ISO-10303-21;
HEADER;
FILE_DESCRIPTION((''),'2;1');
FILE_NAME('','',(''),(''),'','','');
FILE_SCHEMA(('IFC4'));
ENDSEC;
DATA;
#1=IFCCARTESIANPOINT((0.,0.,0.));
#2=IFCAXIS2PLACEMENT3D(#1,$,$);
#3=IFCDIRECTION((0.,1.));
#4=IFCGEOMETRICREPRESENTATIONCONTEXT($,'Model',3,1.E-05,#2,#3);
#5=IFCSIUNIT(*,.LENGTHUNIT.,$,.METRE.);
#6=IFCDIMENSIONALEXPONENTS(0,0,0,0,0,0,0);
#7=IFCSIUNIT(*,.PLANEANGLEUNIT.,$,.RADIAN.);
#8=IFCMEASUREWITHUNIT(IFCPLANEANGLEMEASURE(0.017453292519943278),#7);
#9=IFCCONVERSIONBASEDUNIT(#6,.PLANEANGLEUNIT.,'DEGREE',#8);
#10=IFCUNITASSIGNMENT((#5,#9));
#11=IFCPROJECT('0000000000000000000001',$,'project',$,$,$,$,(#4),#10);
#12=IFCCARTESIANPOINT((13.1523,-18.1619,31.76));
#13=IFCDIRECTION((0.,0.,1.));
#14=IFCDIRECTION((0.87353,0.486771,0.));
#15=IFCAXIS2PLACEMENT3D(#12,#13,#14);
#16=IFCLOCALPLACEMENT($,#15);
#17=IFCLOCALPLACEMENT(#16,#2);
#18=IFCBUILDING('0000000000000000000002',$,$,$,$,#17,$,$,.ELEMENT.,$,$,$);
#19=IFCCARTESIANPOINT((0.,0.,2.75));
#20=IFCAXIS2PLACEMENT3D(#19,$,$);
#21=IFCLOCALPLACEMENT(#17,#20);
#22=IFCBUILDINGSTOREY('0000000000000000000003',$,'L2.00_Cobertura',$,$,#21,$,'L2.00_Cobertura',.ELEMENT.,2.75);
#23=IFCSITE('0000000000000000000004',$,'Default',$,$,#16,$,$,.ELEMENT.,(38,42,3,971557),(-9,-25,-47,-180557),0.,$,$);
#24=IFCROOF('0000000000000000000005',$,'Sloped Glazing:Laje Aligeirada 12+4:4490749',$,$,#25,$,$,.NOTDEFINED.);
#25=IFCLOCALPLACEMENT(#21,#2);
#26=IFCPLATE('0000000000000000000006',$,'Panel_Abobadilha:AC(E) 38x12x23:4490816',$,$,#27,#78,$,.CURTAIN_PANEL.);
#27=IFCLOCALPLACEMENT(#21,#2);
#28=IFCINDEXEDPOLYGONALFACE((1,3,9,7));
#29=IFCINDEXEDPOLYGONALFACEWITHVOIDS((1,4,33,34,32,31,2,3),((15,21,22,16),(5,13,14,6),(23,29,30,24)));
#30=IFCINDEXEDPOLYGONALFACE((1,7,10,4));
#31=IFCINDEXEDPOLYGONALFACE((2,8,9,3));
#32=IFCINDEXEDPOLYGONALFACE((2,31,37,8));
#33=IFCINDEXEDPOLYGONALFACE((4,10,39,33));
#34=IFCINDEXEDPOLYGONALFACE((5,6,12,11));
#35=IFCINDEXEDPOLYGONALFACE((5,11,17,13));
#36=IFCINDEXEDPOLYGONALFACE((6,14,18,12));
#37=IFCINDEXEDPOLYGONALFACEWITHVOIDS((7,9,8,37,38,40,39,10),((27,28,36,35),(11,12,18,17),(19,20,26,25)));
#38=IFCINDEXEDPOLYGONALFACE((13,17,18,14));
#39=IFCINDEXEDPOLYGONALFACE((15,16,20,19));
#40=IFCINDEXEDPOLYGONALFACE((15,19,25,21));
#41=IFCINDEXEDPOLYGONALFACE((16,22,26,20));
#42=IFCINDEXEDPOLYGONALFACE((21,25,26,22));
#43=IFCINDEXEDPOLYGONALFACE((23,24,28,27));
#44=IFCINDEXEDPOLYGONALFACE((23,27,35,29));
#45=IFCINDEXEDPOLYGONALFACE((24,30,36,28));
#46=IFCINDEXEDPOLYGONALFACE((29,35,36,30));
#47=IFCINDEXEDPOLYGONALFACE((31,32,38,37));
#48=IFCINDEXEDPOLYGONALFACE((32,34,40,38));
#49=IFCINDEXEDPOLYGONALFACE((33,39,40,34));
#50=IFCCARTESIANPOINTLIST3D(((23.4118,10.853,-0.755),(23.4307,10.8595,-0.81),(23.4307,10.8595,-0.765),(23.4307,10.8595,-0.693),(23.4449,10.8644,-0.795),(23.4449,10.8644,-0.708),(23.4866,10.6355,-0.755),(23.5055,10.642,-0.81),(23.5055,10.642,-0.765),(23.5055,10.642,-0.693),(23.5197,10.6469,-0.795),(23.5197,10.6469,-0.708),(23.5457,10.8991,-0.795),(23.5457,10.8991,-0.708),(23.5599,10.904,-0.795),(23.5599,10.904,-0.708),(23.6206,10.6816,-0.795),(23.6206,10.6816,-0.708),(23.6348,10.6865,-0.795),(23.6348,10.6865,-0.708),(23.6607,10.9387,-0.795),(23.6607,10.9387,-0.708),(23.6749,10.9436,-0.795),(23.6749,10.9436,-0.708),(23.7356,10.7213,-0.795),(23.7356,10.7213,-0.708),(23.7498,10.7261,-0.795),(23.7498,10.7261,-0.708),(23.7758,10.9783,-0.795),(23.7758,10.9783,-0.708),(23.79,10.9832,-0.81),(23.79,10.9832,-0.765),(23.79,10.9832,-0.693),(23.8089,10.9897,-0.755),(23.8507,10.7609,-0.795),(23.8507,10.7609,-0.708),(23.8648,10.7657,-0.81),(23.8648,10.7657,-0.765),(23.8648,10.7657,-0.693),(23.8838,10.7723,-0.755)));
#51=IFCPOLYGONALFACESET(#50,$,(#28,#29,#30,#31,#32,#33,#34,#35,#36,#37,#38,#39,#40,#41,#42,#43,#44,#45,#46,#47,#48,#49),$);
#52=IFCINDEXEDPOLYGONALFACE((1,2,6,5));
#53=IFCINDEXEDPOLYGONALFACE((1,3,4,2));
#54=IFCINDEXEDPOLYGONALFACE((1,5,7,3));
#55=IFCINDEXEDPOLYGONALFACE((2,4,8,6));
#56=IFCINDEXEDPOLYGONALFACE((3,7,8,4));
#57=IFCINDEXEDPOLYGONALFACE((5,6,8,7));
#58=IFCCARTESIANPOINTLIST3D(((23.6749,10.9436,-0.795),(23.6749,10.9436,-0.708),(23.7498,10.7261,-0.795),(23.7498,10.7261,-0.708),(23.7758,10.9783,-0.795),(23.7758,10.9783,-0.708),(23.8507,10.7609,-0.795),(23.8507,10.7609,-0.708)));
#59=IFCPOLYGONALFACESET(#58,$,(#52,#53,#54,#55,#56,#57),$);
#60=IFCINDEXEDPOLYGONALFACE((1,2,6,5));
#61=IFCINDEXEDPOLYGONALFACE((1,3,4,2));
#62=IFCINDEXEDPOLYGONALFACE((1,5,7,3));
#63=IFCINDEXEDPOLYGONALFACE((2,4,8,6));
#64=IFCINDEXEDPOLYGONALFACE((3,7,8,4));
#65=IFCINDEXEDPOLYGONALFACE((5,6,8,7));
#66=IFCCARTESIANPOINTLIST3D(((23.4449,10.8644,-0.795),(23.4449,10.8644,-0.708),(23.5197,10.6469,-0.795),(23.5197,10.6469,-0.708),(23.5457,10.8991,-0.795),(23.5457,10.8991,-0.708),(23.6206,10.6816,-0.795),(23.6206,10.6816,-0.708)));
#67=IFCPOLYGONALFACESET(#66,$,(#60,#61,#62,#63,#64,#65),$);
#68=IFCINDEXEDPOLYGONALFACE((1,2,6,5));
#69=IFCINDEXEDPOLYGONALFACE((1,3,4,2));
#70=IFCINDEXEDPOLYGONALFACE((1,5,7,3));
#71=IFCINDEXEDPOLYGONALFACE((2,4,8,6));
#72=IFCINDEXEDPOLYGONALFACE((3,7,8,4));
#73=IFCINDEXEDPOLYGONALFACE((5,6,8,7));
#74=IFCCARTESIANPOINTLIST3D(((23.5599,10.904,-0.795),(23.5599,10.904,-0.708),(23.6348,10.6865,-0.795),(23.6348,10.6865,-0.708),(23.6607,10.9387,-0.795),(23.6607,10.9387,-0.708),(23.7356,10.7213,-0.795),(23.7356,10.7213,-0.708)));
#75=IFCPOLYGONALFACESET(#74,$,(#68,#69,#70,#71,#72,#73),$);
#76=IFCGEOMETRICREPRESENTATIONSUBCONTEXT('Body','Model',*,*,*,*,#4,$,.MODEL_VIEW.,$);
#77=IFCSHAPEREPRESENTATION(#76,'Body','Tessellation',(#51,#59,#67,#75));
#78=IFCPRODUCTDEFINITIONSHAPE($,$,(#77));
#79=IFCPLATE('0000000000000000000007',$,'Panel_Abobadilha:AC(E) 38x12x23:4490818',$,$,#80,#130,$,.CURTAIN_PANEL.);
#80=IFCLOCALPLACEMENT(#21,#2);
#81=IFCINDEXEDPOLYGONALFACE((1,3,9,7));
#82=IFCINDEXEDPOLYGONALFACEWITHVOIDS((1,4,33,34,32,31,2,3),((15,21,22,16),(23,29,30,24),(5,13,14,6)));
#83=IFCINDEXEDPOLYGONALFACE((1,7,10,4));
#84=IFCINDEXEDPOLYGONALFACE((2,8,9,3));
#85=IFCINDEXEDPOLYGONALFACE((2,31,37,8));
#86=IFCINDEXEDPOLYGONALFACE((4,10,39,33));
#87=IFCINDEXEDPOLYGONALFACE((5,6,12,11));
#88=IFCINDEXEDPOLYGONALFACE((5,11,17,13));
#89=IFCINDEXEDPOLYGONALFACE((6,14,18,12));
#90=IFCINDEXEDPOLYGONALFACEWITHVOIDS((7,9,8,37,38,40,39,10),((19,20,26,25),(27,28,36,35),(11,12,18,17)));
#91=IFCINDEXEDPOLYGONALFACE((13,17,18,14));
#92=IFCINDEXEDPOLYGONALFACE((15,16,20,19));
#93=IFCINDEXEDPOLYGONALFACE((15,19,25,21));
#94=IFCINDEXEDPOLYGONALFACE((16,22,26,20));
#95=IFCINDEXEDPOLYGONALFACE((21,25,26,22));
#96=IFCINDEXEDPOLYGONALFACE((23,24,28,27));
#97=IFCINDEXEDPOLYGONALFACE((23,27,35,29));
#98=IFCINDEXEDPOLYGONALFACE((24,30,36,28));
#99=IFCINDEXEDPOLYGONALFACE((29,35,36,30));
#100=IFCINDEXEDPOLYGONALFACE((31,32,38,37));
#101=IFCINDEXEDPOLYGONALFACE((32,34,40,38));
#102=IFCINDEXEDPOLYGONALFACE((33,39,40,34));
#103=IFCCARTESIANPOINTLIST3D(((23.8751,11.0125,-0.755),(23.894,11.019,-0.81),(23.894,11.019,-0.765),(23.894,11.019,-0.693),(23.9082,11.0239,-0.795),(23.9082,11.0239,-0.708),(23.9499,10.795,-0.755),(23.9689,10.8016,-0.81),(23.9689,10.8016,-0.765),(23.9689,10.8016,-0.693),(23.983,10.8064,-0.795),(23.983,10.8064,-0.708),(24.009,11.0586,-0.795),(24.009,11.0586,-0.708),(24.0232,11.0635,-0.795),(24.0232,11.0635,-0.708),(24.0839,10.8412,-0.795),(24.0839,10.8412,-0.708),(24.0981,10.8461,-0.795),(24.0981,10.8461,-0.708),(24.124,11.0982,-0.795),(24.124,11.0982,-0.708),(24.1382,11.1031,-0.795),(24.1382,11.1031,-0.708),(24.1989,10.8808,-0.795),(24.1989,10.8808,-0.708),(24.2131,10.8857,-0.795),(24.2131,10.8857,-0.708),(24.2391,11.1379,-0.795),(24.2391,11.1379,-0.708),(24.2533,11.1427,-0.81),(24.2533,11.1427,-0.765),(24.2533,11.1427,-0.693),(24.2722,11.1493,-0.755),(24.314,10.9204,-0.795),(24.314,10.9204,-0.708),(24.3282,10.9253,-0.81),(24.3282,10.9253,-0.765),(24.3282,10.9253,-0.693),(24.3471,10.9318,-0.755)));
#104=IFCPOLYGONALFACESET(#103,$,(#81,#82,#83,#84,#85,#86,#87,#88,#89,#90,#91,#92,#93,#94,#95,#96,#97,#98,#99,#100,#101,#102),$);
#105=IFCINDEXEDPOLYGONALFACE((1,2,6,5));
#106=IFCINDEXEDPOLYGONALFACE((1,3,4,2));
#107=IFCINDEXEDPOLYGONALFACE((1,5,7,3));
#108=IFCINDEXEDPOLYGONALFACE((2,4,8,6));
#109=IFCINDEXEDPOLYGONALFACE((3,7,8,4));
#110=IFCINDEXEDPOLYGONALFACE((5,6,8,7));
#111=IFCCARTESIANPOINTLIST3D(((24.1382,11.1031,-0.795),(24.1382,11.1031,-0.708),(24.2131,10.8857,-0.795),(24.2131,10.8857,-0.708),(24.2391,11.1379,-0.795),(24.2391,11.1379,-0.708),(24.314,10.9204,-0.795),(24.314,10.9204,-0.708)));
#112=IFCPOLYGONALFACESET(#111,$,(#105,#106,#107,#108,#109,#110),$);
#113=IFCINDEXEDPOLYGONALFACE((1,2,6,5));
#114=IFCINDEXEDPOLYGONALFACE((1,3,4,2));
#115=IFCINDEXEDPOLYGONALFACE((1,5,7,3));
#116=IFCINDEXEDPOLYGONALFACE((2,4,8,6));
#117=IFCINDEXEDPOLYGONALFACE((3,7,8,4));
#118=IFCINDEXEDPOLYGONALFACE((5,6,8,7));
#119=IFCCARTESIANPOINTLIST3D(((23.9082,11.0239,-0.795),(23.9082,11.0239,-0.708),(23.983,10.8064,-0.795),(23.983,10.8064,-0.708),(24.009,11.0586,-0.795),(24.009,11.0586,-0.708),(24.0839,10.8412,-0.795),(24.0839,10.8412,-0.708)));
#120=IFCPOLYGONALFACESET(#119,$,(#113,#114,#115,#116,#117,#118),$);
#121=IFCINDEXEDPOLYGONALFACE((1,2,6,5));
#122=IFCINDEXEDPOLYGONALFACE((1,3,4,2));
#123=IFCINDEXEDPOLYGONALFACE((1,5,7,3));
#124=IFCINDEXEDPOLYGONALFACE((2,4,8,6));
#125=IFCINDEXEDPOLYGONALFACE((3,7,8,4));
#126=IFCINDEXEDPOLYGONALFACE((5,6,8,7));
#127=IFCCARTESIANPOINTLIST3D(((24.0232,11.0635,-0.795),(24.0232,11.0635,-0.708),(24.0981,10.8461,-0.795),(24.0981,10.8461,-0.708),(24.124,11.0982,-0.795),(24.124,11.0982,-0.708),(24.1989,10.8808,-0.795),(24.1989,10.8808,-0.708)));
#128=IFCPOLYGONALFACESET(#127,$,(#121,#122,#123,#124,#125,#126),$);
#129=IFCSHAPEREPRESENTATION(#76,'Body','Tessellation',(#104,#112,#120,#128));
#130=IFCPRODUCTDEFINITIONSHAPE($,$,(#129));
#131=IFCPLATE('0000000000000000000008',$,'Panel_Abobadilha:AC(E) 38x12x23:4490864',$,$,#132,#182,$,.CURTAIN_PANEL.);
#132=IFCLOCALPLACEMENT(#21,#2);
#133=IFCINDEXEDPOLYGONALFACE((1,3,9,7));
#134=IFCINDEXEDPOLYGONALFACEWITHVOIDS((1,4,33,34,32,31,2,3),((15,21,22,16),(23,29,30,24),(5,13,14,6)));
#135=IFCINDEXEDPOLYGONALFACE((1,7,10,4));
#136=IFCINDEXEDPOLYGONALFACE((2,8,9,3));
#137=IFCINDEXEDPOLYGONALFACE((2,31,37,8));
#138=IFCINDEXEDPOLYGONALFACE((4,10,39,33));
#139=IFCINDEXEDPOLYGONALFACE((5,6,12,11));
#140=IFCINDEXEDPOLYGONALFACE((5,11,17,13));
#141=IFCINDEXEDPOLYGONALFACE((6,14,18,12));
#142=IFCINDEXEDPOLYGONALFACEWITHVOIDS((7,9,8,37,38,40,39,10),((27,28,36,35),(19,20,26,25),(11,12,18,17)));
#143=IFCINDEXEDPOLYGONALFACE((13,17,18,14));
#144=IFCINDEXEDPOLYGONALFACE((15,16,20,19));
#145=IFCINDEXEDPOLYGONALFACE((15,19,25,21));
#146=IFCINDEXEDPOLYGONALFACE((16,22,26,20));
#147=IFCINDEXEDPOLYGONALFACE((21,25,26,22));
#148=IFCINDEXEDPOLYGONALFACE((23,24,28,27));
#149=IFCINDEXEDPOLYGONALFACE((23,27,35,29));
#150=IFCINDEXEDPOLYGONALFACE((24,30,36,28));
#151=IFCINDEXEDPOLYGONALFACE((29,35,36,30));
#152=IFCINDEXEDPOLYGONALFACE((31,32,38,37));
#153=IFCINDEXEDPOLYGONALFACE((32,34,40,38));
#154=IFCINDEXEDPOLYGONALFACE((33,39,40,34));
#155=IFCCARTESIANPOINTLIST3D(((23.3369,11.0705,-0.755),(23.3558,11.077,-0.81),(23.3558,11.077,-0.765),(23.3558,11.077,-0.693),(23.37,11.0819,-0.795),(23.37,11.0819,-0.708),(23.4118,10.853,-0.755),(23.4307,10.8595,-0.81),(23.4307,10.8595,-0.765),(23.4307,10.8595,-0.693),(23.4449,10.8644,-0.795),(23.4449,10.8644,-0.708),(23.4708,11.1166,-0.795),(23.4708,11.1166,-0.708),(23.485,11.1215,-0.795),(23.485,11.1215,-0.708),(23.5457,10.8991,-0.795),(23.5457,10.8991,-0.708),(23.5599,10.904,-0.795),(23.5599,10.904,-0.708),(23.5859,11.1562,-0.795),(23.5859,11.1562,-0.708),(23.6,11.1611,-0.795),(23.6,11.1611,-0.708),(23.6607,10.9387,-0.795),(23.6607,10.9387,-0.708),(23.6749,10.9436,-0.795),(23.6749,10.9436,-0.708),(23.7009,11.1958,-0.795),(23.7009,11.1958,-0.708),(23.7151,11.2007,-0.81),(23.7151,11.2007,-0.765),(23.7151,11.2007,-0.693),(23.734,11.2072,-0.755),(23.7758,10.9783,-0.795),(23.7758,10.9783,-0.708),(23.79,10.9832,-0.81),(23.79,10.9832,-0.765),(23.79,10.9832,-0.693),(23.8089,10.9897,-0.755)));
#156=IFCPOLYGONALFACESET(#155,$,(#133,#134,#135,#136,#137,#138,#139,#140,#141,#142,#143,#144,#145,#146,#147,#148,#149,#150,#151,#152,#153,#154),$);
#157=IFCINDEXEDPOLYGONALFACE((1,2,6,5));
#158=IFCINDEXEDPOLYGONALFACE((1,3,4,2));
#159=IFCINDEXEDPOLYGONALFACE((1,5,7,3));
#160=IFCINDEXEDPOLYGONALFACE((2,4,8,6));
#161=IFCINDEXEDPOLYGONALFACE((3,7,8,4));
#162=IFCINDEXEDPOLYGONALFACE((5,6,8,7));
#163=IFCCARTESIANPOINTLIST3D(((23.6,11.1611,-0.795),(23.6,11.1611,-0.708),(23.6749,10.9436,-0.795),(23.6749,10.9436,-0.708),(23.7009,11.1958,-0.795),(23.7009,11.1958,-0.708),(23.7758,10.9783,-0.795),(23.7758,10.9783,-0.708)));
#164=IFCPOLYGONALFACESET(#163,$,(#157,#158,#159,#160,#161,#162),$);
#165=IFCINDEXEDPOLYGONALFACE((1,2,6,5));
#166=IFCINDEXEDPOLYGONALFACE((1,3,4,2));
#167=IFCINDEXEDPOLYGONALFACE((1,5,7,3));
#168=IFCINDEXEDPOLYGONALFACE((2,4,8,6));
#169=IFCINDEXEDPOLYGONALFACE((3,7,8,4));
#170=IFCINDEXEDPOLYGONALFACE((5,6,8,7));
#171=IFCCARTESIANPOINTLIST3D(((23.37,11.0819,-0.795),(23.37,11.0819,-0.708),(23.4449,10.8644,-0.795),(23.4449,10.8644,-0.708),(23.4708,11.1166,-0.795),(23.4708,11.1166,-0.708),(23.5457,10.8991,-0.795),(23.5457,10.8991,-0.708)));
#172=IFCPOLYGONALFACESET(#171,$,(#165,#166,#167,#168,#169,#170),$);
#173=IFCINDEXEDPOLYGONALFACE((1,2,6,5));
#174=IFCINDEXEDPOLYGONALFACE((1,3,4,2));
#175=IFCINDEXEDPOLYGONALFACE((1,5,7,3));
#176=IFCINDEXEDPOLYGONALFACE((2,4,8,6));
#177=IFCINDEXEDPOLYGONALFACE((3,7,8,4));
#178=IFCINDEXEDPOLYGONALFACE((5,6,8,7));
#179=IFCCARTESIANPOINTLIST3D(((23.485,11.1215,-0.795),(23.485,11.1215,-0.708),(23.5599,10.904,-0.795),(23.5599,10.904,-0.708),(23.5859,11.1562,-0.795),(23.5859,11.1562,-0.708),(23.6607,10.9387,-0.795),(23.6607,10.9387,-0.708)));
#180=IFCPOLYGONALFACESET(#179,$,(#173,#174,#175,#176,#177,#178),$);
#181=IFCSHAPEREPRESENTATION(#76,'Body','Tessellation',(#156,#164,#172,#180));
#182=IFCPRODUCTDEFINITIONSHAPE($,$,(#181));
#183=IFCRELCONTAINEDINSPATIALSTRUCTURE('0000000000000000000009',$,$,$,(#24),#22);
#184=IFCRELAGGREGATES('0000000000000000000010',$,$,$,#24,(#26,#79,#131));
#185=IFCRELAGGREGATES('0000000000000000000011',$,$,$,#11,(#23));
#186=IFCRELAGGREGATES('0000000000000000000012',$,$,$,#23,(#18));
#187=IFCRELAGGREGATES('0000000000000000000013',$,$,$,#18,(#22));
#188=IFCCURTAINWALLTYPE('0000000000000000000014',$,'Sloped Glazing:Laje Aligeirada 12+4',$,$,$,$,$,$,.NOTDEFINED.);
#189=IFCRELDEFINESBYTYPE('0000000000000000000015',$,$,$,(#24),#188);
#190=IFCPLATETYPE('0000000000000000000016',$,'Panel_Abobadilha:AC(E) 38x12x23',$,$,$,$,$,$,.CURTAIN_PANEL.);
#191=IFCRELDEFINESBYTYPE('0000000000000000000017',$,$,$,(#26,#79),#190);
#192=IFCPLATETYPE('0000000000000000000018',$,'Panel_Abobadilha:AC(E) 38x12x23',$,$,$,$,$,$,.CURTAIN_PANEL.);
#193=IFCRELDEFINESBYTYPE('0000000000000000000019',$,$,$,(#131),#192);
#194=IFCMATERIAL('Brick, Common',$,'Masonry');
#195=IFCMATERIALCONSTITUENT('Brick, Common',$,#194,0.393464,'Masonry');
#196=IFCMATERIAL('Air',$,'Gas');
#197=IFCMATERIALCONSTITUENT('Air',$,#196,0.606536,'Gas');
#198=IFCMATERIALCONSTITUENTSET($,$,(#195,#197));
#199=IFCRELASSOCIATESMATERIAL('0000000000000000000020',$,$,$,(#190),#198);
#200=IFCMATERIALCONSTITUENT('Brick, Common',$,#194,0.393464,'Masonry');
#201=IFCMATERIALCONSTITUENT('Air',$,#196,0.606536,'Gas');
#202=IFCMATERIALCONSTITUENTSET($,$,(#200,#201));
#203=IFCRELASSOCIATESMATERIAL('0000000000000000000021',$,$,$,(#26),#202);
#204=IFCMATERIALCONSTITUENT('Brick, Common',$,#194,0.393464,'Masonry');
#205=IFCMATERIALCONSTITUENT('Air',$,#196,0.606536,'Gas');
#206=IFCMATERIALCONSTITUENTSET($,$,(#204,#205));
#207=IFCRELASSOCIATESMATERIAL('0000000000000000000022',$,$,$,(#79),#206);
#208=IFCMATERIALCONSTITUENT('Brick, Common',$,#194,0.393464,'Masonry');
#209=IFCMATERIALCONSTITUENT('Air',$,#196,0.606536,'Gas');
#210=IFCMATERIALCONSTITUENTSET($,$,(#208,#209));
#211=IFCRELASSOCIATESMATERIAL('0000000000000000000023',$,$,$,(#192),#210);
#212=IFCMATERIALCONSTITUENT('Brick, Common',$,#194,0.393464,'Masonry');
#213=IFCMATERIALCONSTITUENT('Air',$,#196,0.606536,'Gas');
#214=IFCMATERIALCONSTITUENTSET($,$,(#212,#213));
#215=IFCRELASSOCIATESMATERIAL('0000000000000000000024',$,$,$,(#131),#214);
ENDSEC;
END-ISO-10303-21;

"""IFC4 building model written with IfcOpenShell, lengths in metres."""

from ifc_helpers import new_model, entity, si_unit, converted_unit, direction, frame, origin, place, context, subcontext, project, spatial, indexed_curve, outline, extrude, source, transform, mapped, material, constituent, constituent_set, type_object, type_shapes, element, aggregate, save


model = new_model("IFC4")

# Units and contexts
model_context = context("Model", 3, precision=1e-05, world=origin(), true_north=direction((0.0, 1.0)))
body_context = subcontext(model_context, "Body", "Model", "MODEL_VIEW")
ifc_project = project(units=[si_unit("LENGTHUNIT", "METRE"), converted_unit("PLANEANGLEUNIT", "DEGREE", entity("IfcPlaneAngleMeasure", 0.017453292519943278), si_unit("PLANEANGLEUNIT", "RADIAN"), dimensions=[0, 0, 0, 0, 0, 0, 0])], contexts=[model_context])

# Site, building, storey
site_placement = place(None, frame((13.1523, -18.1619, 31.76), z_axis=(0.0, 0.0, 1.0), x_axis=(0.87353, 0.486771, 0.0)))
site = spatial("IfcSite", under=ifc_project, at=site_placement, Name="Default", CompositionType="ELEMENT", RefLatitude=(38, 42, 3, 971557), RefLongitude=(-9, -25, -47, -180557), RefElevation=0.0)
building_placement = place(site_placement, origin())
building = spatial("IfcBuilding", under=site, at=building_placement, CompositionType="ELEMENT")
storey_placement = place(building_placement, frame((0.0, 0.0, 2.75)))
storey = spatial("IfcBuildingStorey", under=building, at=storey_placement, Name="L2.00_Cobertura", LongName="L2.00_Cobertura", CompositionType="ELEMENT", Elevation=2.75)

# Roof, plates
curtain_wall_type = type_object("IfcCurtainWallType", Name="Sloped Glazing:Laje Aligeirada 12+4", PredefinedType="NOTDEFINED")
roof_placement = place(storey_placement, frame((0.0, 0.0, -2.75)))
roof = element("IfcRoof", 1, at=roof_placement, inside=storey, type_object=curtain_wall_type, Name="Sloped Glazing:Laje Aligeirada 12+4:4490749", PredefinedType="NOTDEFINED")
ifc_material_1 = material(Name="Brick, Common", Category="Masonry")
ifc_constituent_1 = constituent(ifc_material_1, Name="Brick, Common", Category="Masonry", fraction=0.393464)
ifc_material_2 = material(Name="Air", Category="Gas")
ifc_constituent_2 = constituent(ifc_material_2, Name="Air", Category="Gas", fraction=0.606536)
ifc_constituent_set_1 = constituent_set(constituents=[ifc_constituent_1, ifc_constituent_2])
ifc_constituent_3 = constituent(ifc_material_1, Name="Brick, Common", Category="Masonry", fraction=0.393464)
ifc_constituent_4 = constituent(ifc_material_2, Name="Air", Category="Gas", fraction=0.606536)
ifc_constituent_set_2 = constituent_set(constituents=[ifc_constituent_3, ifc_constituent_4])
plate_type_1 = type_object("IfcPlateType", Name="Panel_Abobadilha:AC(E) 38x12x23", PredefinedType="CURTAIN_PANEL", material=ifc_constituent_set_2)
shared_shape_1 = source(origin(), body_context, "Body", "SweptSolid", [
    extrude(outline(indexed_curve([(-0.19, -0.0543), (0.19, -0.0543), (0.19, -0.0093), (0.21, 0.0007), (0.19, 0.0628), (-0.19, 0.0628), (-0.21, 0.0007), (-0.19, -0.0093), (-0.19, -0.0543)], self_intersect=False), holes=[indexed_curve([(-0.0683, 0.0477), (-0.0683, -0.0393), (-0.175, -0.0393), (-0.175, 0.0477), (-0.0683, 0.0477)], self_intersect=False), indexed_curve([(0.0533, 0.0477), (0.0533, -0.0393), (-0.0533, -0.0393), (-0.0533, 0.0477), (0.0533, 0.0477)], self_intersect=False), indexed_curve([(0.175, 0.0477), (0.175, -0.0393), (0.0683, -0.0393), (0.0683, 0.0477), (0.175, 0.0477)], self_intersect=False)]), frame((0.0, 0.0543, 0.0)), (0.0, 0.0, 1.0), 0.23),
    extrude(outline(indexed_curve([(-0.0533, -0.0435), (0.0533, -0.0435), (0.0533, 0.0435), (-0.0533, 0.0435), (-0.0533, -0.0435)], self_intersect=False)), frame((0.1217, 0.0585, 0.0), z_axis=(0.0, 0.0, 1.0), x_axis=(-1.0, 0.0, 0.0)), (0.0, 0.0, 1.0), 0.23),
    extrude(outline(indexed_curve([(-0.0533, -0.0435), (0.0533, -0.0435), (0.0533, 0.0435), (-0.0533, 0.0435), (-0.0533, -0.0435)], self_intersect=False)), frame((-0.1217, 0.0585, 0.0), z_axis=(0.0, 0.0, 1.0), x_axis=(-1.0, 0.0, 0.0)), (0.0, 0.0, 1.0), 0.23),
    extrude(outline(indexed_curve([(-0.0533, -0.0435), (0.0533, -0.0435), (0.0533, 0.0435), (-0.0533, 0.0435), (-0.0533, -0.0435)], self_intersect=False)), frame((0.0, 0.0585, 0.0), z_axis=(0.0, 0.0, 1.0), x_axis=(-1.0, 0.0, 0.0)), (0.0, 0.0, 1.0), 0.23),
])
type_shapes(plate_type_1, [shared_shape_1])
plate_1_placement = place(roof_placement, frame((23.6103, 10.9214, 1.94), z_axis=(0.325568, -0.945519, 0.0), x_axis=(0.945519, 0.325568, 0.0)))
plate_1 = element("IfcPlate", 2, at=plate_1_placement, type_object=plate_type_1, material=ifc_constituent_set_1, Name="Panel_Abobadilha:AC(E) 38x12x23:4490816", PredefinedType="CURTAIN_PANEL", context=body_context, shape_type="MappedRepresentation", body=[
    mapped(shared_shape_1, transform((0.0, 0.0, 0.0), scale=1.0)),
])
ifc_constituent_5 = constituent(ifc_material_1, Name="Brick, Common", Category="Masonry", fraction=0.393464)
ifc_constituent_6 = constituent(ifc_material_2, Name="Air", Category="Gas", fraction=0.606536)
ifc_constituent_set_3 = constituent_set(constituents=[ifc_constituent_5, ifc_constituent_6])
plate_2_placement = place(roof_placement, frame((24.0736, 11.0809, 1.94), z_axis=(0.325568, -0.945519, 0.0), x_axis=(0.945519, 0.325568, 0.0)))
plate_2 = element("IfcPlate", 3, at=plate_2_placement, type_object=plate_type_1, material=ifc_constituent_set_3, Name="Panel_Abobadilha:AC(E) 38x12x23:4490818", PredefinedType="CURTAIN_PANEL", context=body_context, shape_type="MappedRepresentation", body=[
    mapped(shared_shape_1, transform((0.0, 0.0, 0.0), scale=1.0)),
])
ifc_constituent_7 = constituent(ifc_material_1, Name="Brick, Common", Category="Masonry", fraction=0.393464)
ifc_constituent_8 = constituent(ifc_material_2, Name="Air", Category="Gas", fraction=0.606536)
ifc_constituent_set_4 = constituent_set(constituents=[ifc_constituent_7, ifc_constituent_8])
ifc_constituent_9 = constituent(ifc_material_1, Name="Brick, Common", Category="Masonry", fraction=0.393464)
ifc_constituent_10 = constituent(ifc_material_2, Name="Air", Category="Gas", fraction=0.606536)
ifc_constituent_set_5 = constituent_set(constituents=[ifc_constituent_9, ifc_constituent_10])
plate_type_2 = type_object("IfcPlateType", Name="Panel_Abobadilha:AC(E) 38x12x23", PredefinedType="CURTAIN_PANEL", material=ifc_constituent_set_5)
shared_shape_2 = source(origin(), body_context, "Body", "SweptSolid", [
    extrude(outline(indexed_curve([(-0.19, -0.0543), (0.19, -0.0543), (0.19, -0.0093), (0.21, 0.0007), (0.19, 0.0628), (-0.19, 0.0628), (-0.21, 0.0007), (-0.19, -0.0093), (-0.19, -0.0543)], self_intersect=False), holes=[indexed_curve([(-0.0683, 0.0477), (-0.0683, -0.0393), (-0.175, -0.0393), (-0.175, 0.0477), (-0.0683, 0.0477)], self_intersect=False), indexed_curve([(0.0533, 0.0477), (0.0533, -0.0393), (-0.0533, -0.0393), (-0.0533, 0.0477), (0.0533, 0.0477)], self_intersect=False), indexed_curve([(0.175, 0.0477), (0.175, -0.0393), (0.0683, -0.0393), (0.0683, 0.0477), (0.175, 0.0477)], self_intersect=False)]), frame((0.0, 0.0543, 0.0)), (0.0, 0.0, 1.0), 0.23),
    extrude(outline(indexed_curve([(-0.0533, -0.0435), (0.0533, -0.0435), (0.0533, 0.0435), (-0.0533, 0.0435), (-0.0533, -0.0435)], self_intersect=False)), frame((0.1217, 0.0585, 0.0), z_axis=(0.0, 0.0, 1.0), x_axis=(-1.0, 0.0, 0.0)), (0.0, 0.0, 1.0), 0.23),
    extrude(outline(indexed_curve([(-0.0533, -0.0435), (0.0533, -0.0435), (0.0533, 0.0435), (-0.0533, 0.0435), (-0.0533, -0.0435)], self_intersect=False)), frame((-0.1217, 0.0585, 0.0), z_axis=(0.0, 0.0, 1.0), x_axis=(-1.0, 0.0, 0.0)), (0.0, 0.0, 1.0), 0.23),
    extrude(outline(indexed_curve([(-0.0533, -0.0435), (0.0533, -0.0435), (0.0533, 0.0435), (-0.0533, 0.0435), (-0.0533, -0.0435)], self_intersect=False)), frame((0.0, 0.0585, 0.0), z_axis=(0.0, 0.0, 1.0), x_axis=(-1.0, 0.0, 0.0)), (0.0, 0.0, 1.0), 0.23),
])
type_shapes(plate_type_2, [shared_shape_2])
plate_3_placement = place(roof_placement, frame((23.5354, 11.1388, 1.94), z_axis=(0.325568, -0.945519, 0.0), x_axis=(0.945519, 0.325568, 0.0)))
plate_3 = element("IfcPlate", 4, at=plate_3_placement, type_object=plate_type_2, material=ifc_constituent_set_4, Name="Panel_Abobadilha:AC(E) 38x12x23:4490864", PredefinedType="CURTAIN_PANEL", context=body_context, shape_type="MappedRepresentation", body=[
    mapped(shared_shape_2, transform((0.0, 0.0, 0.0), scale=1.0)),
])
aggregate(roof, [plate_1, plate_2, plate_3])

save(model, "model.ifc")
